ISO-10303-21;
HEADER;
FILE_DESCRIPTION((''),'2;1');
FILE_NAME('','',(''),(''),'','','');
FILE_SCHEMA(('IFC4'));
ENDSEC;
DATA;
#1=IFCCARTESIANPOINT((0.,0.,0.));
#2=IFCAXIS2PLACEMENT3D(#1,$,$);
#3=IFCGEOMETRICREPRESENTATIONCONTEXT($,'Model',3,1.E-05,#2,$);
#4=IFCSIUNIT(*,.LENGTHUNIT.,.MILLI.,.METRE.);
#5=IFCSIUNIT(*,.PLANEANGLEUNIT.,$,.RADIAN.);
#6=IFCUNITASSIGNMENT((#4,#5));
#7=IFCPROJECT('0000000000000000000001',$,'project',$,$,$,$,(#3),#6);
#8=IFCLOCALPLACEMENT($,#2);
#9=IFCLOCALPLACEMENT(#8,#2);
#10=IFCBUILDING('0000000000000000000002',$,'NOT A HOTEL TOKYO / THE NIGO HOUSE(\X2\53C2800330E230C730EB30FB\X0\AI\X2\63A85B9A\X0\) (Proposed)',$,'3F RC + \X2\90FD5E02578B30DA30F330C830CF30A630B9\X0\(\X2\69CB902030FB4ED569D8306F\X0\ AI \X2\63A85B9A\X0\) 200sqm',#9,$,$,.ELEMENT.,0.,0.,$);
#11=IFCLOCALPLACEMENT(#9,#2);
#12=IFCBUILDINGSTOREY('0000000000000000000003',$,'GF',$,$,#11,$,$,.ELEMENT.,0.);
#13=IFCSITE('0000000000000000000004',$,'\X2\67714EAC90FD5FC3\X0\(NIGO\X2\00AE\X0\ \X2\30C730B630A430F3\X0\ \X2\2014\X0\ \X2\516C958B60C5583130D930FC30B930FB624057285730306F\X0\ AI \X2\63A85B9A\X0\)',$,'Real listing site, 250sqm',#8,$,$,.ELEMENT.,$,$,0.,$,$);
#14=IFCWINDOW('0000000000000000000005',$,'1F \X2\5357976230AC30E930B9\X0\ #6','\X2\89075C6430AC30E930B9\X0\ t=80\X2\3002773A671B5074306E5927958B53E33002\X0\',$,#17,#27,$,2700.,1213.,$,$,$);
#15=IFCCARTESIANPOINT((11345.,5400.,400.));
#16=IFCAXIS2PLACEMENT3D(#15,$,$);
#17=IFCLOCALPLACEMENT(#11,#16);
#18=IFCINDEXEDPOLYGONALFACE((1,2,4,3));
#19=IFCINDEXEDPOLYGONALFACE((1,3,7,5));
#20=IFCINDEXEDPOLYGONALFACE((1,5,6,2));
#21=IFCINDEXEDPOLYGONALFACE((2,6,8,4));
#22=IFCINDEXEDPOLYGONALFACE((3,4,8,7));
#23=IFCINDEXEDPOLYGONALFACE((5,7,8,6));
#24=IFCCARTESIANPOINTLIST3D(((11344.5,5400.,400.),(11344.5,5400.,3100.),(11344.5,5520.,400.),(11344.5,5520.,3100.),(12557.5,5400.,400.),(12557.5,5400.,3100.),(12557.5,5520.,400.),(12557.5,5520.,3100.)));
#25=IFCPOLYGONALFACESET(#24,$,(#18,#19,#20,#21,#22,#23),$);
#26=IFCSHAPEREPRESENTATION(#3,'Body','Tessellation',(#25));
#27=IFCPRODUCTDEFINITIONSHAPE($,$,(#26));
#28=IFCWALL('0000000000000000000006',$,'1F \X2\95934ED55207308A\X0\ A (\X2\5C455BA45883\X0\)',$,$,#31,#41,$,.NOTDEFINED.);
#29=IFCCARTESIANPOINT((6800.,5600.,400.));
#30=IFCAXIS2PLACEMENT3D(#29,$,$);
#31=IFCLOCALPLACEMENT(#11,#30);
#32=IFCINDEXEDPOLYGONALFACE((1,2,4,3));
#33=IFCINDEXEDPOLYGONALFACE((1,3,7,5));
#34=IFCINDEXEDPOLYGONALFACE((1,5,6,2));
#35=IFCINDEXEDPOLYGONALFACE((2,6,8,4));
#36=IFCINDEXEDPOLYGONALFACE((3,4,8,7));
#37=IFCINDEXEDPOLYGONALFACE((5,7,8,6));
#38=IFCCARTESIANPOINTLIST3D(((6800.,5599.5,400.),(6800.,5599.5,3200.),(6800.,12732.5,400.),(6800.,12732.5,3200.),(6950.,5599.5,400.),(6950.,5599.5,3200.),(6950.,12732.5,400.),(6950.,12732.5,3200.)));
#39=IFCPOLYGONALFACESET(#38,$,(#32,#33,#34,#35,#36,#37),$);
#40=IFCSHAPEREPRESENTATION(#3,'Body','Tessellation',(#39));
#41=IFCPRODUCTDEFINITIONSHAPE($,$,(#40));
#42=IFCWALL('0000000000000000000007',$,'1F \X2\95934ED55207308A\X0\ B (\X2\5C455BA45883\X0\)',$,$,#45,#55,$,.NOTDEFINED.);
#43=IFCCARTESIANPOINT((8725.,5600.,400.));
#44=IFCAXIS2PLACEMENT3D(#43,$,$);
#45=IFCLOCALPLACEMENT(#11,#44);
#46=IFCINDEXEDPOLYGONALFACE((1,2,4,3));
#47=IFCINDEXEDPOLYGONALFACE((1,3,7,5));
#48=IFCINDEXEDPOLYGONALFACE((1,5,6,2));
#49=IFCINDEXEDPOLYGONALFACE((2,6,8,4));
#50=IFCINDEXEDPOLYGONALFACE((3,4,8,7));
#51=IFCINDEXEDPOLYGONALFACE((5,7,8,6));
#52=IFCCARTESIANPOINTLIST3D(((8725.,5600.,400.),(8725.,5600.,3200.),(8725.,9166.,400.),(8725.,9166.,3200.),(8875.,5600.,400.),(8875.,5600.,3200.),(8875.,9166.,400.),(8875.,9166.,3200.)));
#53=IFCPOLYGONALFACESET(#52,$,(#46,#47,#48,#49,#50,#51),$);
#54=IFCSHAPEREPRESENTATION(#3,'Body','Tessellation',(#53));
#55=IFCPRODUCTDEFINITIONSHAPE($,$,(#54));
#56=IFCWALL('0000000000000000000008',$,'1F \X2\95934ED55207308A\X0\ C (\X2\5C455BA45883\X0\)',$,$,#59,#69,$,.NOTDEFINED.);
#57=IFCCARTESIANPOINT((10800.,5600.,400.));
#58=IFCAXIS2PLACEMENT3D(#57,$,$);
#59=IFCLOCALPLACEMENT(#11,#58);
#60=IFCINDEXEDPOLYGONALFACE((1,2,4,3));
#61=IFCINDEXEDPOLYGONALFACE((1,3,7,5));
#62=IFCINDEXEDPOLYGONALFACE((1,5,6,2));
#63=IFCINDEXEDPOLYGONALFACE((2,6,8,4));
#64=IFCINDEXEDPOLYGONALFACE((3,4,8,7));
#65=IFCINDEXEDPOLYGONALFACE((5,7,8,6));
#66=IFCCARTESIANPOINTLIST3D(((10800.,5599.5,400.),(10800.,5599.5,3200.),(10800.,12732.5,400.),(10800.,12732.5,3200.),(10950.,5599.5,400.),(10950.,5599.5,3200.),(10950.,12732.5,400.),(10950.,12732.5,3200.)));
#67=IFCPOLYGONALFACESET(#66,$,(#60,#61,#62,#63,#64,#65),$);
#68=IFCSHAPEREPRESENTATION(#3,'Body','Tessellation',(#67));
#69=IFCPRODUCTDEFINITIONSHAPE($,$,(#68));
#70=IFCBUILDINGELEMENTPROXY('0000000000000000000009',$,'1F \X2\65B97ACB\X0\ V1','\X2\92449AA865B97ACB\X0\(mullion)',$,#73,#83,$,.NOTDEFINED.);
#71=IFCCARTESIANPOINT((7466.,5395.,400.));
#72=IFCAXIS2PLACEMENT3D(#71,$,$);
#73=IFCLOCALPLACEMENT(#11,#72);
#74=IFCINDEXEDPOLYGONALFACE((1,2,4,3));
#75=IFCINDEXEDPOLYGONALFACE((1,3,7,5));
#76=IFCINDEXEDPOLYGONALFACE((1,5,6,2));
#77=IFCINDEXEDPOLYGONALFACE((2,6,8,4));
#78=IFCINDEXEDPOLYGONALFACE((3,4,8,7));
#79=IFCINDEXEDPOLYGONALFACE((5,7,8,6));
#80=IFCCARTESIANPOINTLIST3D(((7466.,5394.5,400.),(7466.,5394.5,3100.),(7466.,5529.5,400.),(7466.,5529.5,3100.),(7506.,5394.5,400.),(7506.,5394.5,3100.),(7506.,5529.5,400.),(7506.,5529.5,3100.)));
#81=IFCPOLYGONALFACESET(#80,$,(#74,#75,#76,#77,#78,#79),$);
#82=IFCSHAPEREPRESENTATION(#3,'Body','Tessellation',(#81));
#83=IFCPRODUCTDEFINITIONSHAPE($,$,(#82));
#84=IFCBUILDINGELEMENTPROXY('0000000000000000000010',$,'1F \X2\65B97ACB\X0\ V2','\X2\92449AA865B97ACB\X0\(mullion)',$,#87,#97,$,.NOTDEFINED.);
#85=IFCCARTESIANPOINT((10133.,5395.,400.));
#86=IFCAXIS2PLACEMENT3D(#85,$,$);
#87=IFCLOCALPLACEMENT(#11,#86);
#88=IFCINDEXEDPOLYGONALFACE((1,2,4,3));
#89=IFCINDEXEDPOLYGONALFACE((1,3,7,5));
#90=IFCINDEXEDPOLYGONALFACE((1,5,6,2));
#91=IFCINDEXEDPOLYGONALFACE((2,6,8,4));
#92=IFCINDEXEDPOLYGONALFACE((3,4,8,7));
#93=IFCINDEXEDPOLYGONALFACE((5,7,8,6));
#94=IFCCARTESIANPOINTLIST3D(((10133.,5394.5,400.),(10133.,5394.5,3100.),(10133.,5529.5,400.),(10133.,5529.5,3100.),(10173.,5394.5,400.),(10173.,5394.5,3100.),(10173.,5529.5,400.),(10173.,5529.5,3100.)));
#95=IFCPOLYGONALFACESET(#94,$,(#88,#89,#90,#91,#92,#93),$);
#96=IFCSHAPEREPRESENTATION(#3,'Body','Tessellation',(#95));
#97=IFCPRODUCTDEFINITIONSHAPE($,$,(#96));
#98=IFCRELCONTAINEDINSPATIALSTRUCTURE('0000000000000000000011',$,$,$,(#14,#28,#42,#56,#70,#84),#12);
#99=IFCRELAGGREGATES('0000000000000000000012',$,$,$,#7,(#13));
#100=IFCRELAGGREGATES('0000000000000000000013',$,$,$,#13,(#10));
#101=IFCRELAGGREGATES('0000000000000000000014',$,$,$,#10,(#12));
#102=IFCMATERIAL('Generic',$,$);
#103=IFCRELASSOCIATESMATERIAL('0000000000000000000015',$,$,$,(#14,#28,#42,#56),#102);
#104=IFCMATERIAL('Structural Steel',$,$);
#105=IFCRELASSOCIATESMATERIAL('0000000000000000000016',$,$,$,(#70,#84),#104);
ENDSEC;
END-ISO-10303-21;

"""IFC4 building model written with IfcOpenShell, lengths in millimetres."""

from ifc_helpers import new_model, si_unit, frame, frame_2d, origin, place, context, project, spatial, rectangle, extrude, material, element, save


model = new_model("IFC4")

# Units and contexts
model_context = context("Model", 3, precision=1e-05, world=origin())
ifc_project = project(units=[si_unit("LENGTHUNIT", "METRE", prefix="MILLI"), si_unit("PLANEANGLEUNIT", "RADIAN")], contexts=[model_context])

# Site, building, storey
site_placement = place(None, origin())
site = spatial("IfcSite", under=ifc_project, at=site_placement, Name="東京都心(NIGO® デザイン — 公開情報ベース・所在地は AI 推定)", ObjectType="Real listing site, 250sqm", CompositionType="ELEMENT", RefElevation=0.0)
building_placement = place(site_placement, origin())
building = spatial("IfcBuilding", under=site, at=building_placement, Name="NOT A HOTEL TOKYO / THE NIGO HOUSE(参考モデル・AI推定) (Proposed)", ObjectType="3F RC + 都市型ペントハウス(構造・仕様は AI 推定) 200sqm", CompositionType="ELEMENT", ElevationOfRefHeight=0.0, ElevationOfTerrain=0.0)
storey_placement = place(building_placement, origin())
storey = spatial("IfcBuildingStorey", under=building, at=storey_placement, Name="GF", CompositionType="ELEMENT", Elevation=0.0)

# Shared definitions
ifc_material_1 = material(Name="Generic")

# Window
window_1_placement = place(storey_placement, frame((11345.0, 5400.0, 400.0)))
element("IfcWindow", 1, at=window_1_placement, inside=storey, material=ifc_material_1, Name="1F 南面ガラス #6", Description="複層ガラス t=80。眺望側の大開口。", OverallHeight=2700.0, OverallWidth=1213.0, context=model_context, shape_type="SweptSolid", body=[
    extrude(rectangle(XDim=1213.0, YDim=120.0, at=frame_2d((606.0, 60.0))), frame((11345.0, 5400.0, 400.0)), (0.0, 0.0, 1.0), 2700.0),
])

# Walls
wall_1_placement = place(storey_placement, frame((6800.0, 5600.0, 400.0)))
element("IfcWall", 2, at=wall_1_placement, inside=storey, material=ifc_material_1, Name="1F 間仕切り A (居室境)", PredefinedType="NOTDEFINED", context=model_context, shape_type="SweptSolid", body=[
    extrude(rectangle(XDim=150.0, YDim=7133.0, at=frame_2d((75.0, 3566.0))), frame((6800.0, 5600.0, 400.0)), (0.0, 0.0, 1.0), 2800.0),
])
wall_2_placement = place(storey_placement, frame((8725.0, 5600.0, 400.0)))
element("IfcWall", 3, at=wall_2_placement, inside=storey, material=ifc_material_1, Name="1F 間仕切り B (居室境)", PredefinedType="NOTDEFINED", context=model_context, shape_type="SweptSolid", body=[
    extrude(rectangle(XDim=150.0, YDim=3566.0, at=frame_2d((75.0, 1783.0))), frame((8725.0, 5600.0, 400.0)), (0.0, 0.0, 1.0), 2800.0),
])
wall_3_placement = place(storey_placement, frame((10800.0, 5600.0, 400.0)))
element("IfcWall", 4, at=wall_3_placement, inside=storey, material=ifc_material_1, Name="1F 間仕切り C (居室境)", PredefinedType="NOTDEFINED", context=model_context, shape_type="SweptSolid", body=[
    extrude(rectangle(XDim=150.0, YDim=7133.0, at=frame_2d((75.0, 3566.0))), frame((10800.0, 5600.0, 400.0)), (0.0, 0.0, 1.0), 2800.0),
])

# Building element proxies
ifc_material_2 = material(Name="Structural Steel")
proxy_1_placement = place(storey_placement, frame((7466.0, 5395.0, 400.0)))
element("IfcBuildingElementProxy", 5, at=proxy_1_placement, inside=storey, material=ifc_material_2, Name="1F 方立 V1", Description="鉄骨方立(mullion)", PredefinedType="NOTDEFINED", context=model_context, shape_type="SweptSolid", body=[
    extrude(rectangle(XDim=40.0, YDim=135.0, at=frame_2d((20.0, 67.0))), frame((7466.0, 5395.0, 400.0)), (0.0, 0.0, 1.0), 2700.0),
])
proxy_2_placement = place(storey_placement, frame((10133.0, 5395.0, 400.0)))
element("IfcBuildingElementProxy", 6, at=proxy_2_placement, inside=storey, material=ifc_material_2, Name="1F 方立 V2", Description="鉄骨方立(mullion)", PredefinedType="NOTDEFINED", context=model_context, shape_type="SweptSolid", body=[
    extrude(rectangle(XDim=40.0, YDim=135.0, at=frame_2d((20.0, 67.0))), frame((10133.0, 5395.0, 400.0)), (0.0, 0.0, 1.0), 2700.0),
])

save(model, "model.ifc")
